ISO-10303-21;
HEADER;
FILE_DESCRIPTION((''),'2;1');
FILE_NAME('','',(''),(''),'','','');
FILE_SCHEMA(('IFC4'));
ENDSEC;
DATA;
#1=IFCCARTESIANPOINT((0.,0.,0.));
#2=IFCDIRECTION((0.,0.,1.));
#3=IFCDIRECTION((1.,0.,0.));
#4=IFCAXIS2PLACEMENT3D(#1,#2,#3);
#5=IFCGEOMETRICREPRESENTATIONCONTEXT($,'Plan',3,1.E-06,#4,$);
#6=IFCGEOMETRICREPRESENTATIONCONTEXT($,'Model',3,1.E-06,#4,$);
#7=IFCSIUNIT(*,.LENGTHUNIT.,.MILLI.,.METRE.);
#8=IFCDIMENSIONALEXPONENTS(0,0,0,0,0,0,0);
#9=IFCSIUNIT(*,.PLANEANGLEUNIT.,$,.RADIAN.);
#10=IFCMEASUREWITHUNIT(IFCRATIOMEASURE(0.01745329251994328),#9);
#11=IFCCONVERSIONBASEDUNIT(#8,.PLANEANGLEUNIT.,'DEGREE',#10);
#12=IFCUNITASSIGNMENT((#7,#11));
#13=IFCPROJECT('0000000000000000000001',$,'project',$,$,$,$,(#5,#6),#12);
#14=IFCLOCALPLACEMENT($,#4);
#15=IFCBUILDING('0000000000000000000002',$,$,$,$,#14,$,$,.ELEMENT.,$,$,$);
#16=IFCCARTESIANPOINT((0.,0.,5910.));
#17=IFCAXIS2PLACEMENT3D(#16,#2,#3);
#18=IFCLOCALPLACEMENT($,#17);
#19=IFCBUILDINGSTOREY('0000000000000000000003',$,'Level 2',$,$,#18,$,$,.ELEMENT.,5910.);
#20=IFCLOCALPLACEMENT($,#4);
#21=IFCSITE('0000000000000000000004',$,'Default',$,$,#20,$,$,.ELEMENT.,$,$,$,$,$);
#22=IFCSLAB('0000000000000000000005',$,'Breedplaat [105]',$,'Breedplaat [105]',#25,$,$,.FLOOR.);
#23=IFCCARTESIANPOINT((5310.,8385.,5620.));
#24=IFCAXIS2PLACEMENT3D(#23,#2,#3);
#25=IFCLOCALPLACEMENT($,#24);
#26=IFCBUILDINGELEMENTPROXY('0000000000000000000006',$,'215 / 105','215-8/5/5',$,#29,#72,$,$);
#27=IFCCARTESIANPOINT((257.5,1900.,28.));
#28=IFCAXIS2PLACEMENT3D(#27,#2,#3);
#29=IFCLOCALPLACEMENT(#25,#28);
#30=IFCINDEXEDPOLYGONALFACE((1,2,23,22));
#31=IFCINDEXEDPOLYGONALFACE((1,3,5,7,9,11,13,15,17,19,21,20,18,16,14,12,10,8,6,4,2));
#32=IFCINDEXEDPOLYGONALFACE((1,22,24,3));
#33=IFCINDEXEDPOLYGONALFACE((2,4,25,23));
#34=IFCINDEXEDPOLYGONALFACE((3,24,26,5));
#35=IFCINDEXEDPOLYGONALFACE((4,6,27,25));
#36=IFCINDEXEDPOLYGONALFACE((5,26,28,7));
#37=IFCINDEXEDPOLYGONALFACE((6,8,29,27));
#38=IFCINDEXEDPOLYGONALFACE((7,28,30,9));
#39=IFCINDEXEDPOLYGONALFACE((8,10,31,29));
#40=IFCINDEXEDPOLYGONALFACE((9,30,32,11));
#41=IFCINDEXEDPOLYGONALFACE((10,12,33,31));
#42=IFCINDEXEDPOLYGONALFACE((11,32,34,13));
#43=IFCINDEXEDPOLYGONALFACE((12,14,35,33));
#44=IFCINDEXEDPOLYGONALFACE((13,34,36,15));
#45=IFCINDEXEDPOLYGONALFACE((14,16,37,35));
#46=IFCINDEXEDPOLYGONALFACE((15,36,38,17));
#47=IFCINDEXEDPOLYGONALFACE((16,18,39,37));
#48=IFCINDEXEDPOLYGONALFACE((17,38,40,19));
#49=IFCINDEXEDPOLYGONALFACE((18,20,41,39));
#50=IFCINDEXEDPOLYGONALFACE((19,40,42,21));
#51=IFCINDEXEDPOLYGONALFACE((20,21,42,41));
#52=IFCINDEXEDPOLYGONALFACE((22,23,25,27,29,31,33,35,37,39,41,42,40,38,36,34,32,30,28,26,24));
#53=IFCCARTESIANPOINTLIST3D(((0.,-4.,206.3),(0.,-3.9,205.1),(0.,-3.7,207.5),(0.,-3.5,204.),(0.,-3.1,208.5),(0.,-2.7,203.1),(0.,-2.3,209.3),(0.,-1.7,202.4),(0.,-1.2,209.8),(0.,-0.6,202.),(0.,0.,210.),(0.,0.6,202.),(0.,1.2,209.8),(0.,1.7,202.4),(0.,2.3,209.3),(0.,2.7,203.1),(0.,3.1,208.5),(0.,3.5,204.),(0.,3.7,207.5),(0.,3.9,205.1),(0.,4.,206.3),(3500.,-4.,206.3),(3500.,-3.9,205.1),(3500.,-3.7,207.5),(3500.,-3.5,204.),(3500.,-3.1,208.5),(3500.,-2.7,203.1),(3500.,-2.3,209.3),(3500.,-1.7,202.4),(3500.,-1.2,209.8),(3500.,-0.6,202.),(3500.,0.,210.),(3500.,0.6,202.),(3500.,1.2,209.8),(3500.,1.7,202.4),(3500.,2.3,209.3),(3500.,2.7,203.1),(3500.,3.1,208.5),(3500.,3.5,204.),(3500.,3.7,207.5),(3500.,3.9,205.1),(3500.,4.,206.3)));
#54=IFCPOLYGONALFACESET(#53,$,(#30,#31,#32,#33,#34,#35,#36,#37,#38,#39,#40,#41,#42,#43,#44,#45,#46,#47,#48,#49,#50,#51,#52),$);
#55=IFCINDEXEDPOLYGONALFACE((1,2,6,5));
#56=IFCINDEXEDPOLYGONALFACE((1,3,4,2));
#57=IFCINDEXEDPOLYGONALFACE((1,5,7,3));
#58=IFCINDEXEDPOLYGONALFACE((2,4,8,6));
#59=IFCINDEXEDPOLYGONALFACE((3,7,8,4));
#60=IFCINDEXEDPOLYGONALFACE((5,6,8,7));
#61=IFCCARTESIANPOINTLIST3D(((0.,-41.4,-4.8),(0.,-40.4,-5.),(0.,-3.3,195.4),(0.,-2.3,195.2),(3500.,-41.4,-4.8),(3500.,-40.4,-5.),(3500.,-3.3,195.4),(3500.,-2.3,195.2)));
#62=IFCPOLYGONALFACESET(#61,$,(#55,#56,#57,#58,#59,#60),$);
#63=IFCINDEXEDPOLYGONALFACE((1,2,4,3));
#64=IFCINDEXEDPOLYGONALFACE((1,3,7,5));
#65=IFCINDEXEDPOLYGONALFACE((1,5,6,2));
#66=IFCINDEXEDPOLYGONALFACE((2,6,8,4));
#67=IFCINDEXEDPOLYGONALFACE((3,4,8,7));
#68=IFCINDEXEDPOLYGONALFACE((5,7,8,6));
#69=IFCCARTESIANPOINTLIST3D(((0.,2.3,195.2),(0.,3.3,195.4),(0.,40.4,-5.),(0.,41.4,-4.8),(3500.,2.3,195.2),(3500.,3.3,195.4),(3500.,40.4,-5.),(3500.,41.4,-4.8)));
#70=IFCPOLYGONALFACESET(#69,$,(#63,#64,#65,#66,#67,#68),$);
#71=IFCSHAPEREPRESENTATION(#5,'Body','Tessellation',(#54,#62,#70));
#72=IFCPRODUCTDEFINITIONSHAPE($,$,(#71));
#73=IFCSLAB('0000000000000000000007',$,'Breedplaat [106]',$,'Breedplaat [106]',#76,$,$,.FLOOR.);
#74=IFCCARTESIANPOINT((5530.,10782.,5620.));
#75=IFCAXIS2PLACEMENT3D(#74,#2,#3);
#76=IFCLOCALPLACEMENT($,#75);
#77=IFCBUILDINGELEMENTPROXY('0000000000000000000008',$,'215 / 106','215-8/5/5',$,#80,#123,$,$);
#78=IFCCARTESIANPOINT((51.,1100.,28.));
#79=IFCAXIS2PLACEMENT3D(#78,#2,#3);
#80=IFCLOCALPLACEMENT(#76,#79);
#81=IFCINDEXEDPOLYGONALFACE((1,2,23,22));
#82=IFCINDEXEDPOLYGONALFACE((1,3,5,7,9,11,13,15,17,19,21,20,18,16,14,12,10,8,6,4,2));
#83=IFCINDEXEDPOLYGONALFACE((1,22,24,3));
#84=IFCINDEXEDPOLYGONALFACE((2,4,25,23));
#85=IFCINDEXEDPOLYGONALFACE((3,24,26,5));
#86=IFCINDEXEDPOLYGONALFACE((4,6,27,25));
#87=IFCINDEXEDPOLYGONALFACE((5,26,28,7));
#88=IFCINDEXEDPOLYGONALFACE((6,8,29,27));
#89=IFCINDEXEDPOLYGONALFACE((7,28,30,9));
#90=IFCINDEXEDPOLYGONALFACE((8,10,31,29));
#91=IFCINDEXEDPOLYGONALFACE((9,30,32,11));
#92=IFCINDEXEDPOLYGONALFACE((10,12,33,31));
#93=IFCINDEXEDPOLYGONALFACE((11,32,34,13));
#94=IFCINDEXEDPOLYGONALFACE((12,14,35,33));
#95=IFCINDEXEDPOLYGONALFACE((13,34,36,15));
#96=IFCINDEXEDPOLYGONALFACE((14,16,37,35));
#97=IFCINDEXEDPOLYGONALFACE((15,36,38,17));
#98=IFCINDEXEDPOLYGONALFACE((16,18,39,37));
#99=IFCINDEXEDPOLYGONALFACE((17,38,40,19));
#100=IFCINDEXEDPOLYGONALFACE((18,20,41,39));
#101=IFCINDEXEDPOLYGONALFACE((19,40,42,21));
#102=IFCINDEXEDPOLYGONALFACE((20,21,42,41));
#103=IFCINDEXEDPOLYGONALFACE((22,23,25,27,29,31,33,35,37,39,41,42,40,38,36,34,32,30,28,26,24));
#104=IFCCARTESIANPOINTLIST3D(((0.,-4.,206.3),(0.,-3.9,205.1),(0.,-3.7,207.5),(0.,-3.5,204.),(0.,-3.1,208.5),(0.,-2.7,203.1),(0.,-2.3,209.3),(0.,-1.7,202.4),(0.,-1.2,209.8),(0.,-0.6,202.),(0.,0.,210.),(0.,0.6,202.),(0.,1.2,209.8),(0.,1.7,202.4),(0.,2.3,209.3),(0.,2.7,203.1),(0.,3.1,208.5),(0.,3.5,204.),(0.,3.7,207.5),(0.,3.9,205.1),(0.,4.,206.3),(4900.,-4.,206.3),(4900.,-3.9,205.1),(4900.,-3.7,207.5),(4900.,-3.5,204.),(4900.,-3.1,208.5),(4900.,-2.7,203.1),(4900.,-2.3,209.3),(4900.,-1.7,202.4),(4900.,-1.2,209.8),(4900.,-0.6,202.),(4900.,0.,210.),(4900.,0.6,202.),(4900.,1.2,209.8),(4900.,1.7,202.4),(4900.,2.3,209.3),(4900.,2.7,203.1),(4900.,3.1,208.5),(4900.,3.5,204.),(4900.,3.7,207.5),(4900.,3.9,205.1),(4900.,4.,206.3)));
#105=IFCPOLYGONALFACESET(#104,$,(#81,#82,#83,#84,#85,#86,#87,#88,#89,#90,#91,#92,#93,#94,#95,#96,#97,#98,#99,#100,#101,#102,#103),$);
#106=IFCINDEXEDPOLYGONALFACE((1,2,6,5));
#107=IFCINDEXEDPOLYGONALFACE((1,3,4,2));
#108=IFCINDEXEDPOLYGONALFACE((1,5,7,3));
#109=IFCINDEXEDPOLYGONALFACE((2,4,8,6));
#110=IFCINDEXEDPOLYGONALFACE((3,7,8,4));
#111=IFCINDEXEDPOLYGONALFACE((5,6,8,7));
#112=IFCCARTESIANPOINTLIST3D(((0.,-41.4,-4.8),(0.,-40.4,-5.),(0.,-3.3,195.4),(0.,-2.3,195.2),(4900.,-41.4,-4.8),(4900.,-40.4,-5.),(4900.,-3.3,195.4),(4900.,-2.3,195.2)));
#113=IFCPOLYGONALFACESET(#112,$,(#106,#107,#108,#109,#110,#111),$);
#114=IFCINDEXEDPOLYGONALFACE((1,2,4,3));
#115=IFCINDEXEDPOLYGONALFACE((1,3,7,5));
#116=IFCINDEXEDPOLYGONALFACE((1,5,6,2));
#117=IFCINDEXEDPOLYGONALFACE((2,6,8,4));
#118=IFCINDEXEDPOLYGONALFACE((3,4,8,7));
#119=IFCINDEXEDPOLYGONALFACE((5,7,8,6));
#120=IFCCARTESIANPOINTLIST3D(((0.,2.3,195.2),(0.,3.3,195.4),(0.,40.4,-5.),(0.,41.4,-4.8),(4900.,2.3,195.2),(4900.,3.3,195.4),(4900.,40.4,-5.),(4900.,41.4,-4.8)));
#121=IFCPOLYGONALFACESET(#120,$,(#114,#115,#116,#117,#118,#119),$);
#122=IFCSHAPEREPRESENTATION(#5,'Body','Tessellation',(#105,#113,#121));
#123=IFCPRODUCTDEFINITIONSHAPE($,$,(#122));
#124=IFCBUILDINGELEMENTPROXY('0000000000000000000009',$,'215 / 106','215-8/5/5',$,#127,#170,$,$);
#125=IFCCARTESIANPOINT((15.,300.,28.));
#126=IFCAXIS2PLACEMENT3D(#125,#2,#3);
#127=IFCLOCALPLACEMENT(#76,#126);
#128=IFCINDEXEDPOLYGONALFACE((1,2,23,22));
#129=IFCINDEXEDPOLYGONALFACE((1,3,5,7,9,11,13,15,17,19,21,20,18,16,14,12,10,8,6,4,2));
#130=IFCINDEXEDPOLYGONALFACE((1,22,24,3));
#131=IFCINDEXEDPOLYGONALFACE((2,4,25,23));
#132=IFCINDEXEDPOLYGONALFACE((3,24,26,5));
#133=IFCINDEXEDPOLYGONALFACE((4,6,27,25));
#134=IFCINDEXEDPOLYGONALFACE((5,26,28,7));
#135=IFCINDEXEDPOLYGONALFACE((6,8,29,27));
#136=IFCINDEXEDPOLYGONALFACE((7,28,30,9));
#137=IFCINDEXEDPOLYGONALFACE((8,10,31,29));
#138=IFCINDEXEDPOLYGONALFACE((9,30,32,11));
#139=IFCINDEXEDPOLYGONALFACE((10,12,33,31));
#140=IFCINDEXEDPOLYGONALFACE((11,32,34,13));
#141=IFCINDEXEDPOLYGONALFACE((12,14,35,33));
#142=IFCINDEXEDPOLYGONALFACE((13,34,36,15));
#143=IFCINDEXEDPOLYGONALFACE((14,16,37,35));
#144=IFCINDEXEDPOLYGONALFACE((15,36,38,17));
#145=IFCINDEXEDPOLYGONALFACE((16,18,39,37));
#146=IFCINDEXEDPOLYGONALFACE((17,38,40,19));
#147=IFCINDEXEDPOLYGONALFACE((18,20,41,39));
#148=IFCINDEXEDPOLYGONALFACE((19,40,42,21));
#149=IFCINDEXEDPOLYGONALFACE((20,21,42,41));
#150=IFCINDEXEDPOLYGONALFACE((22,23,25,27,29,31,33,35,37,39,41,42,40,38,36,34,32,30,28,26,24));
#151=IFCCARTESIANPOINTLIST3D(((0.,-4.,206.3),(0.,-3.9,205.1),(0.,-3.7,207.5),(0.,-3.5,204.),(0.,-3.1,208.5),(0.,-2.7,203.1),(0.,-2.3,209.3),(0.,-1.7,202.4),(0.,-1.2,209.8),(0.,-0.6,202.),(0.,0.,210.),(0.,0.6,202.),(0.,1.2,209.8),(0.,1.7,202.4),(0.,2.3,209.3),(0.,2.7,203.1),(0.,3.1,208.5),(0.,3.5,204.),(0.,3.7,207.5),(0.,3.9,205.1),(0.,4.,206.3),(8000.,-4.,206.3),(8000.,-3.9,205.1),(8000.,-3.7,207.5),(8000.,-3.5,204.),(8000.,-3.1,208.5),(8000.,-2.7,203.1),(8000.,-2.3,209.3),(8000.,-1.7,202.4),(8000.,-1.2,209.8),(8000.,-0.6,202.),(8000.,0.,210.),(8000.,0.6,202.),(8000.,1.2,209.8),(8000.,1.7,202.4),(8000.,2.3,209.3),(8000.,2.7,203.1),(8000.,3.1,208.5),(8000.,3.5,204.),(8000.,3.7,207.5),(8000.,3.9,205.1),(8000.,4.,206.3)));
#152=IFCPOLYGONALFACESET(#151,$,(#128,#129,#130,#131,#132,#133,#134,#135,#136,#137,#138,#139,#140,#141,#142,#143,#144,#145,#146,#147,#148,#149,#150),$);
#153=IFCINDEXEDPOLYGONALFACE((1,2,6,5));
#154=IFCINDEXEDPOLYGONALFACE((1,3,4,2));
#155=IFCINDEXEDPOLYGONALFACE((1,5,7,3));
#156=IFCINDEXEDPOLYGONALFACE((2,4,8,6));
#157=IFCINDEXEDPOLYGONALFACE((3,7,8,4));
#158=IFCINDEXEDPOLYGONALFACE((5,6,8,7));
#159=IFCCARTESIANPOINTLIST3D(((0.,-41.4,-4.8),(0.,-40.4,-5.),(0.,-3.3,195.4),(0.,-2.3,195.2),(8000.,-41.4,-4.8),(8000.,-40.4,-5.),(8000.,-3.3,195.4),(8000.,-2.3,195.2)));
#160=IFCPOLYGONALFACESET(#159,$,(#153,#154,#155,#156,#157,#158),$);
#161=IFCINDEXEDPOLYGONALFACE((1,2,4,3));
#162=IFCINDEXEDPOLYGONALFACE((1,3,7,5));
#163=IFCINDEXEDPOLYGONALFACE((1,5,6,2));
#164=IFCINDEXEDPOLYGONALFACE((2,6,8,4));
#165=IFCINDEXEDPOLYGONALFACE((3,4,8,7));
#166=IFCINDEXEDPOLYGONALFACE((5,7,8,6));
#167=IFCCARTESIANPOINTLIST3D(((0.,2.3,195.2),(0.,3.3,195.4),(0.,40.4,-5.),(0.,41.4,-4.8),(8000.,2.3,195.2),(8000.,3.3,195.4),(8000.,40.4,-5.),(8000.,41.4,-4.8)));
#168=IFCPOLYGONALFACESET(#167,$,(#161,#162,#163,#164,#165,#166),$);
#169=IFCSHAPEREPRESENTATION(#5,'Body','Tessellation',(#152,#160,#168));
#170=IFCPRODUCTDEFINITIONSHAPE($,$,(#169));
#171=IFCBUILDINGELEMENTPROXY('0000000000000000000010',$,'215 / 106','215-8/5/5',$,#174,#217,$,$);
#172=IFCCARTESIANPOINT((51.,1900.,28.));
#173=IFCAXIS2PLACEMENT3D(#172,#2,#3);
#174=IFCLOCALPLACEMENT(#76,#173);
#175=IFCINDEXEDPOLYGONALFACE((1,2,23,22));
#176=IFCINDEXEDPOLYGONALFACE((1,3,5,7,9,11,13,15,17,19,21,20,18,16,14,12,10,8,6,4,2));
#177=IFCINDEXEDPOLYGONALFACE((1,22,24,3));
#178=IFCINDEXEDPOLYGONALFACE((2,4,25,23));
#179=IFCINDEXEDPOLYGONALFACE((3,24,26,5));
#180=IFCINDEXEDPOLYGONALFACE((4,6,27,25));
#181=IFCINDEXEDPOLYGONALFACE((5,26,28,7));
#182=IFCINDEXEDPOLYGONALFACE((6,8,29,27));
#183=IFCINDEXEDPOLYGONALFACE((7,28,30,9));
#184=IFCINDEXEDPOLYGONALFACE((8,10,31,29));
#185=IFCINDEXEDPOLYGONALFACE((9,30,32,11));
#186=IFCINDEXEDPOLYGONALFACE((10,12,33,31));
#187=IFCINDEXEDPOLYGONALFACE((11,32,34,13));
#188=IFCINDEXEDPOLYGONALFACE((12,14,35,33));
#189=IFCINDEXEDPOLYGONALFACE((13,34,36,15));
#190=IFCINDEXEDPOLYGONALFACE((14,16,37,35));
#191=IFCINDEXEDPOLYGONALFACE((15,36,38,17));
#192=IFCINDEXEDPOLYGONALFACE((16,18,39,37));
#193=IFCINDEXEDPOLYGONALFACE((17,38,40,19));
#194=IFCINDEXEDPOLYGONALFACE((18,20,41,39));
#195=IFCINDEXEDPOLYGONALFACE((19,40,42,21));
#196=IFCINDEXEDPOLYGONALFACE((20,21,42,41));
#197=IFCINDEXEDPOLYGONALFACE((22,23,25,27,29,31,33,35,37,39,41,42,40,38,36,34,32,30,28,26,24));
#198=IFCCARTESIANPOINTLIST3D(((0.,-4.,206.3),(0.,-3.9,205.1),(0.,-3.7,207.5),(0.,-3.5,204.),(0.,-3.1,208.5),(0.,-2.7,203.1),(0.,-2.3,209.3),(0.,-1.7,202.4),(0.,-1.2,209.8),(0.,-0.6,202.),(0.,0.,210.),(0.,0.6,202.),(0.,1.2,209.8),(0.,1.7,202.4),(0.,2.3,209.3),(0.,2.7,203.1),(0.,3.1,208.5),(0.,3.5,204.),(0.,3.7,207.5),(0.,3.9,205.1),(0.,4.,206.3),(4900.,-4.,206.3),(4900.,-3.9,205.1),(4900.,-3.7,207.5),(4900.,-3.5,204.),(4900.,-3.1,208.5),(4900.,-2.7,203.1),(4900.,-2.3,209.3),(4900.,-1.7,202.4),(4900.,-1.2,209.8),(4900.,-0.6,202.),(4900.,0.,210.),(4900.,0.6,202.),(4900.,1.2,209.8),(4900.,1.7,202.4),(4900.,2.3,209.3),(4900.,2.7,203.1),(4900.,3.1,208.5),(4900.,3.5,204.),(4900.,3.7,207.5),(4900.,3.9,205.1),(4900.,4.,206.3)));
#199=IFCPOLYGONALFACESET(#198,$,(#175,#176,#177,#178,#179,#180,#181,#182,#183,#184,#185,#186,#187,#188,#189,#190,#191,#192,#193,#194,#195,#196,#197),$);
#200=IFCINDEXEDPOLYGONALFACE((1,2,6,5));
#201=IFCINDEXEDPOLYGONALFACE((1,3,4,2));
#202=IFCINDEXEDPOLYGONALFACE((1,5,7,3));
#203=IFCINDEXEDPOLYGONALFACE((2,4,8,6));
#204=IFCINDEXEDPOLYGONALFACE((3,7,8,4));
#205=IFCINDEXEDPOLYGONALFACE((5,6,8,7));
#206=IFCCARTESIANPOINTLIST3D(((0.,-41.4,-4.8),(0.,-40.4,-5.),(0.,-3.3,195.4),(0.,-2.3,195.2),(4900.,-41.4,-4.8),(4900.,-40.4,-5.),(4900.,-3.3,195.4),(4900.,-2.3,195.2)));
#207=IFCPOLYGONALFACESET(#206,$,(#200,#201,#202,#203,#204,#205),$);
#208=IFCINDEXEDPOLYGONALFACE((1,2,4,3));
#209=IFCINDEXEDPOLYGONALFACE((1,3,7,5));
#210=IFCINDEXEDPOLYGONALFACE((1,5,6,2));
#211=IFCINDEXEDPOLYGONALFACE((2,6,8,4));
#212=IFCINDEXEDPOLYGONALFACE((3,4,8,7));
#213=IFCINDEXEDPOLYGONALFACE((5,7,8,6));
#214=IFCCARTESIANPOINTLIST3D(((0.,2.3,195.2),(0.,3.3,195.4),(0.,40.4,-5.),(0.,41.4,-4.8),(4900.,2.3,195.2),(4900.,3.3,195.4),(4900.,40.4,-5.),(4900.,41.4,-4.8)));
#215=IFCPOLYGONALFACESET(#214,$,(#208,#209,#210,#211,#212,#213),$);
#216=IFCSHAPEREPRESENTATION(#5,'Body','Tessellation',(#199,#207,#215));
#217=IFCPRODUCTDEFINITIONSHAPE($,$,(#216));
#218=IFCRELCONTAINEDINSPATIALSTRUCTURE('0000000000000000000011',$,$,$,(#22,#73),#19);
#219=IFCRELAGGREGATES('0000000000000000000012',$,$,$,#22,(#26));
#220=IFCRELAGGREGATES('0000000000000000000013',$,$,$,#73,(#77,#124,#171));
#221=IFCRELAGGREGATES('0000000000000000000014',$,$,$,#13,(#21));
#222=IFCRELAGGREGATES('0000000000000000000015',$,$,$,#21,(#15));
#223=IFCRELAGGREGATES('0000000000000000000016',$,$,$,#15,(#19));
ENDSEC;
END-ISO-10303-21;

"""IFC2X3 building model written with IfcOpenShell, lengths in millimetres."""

from ifc_helpers import new_model, entity, si_unit, converted_unit, frame, origin_with_axes, origin_2d_with_axis, place, context, project, spatial, rectangle, circle, extrude, element, aggregate, save


model = new_model("IFC2X3")

# Units and contexts
plan_context = context("Plan", 3, precision=1e-06, world=origin_with_axes())
model_context = context("Model", 3, precision=1e-06, world=origin_with_axes())
ifc_project = project(units=[si_unit("LENGTHUNIT", "METRE", prefix="MILLI"), converted_unit("PLANEANGLEUNIT", "DEGREE", entity("IfcRatioMeasure", 0.01745329251994328), si_unit("PLANEANGLEUNIT", "RADIAN"), dimensions=[0, 0, 0, 0, 0, 0, 0])], contexts=[plan_context, model_context])

# Site, building, storey
site_placement = place(None, origin_with_axes())
site = spatial("IfcSite", under=ifc_project, at=site_placement, Name="Default", CompositionType="ELEMENT")
building_placement = place(None, origin_with_axes())
building = spatial("IfcBuilding", under=site, at=building_placement, CompositionType="ELEMENT")
storey_placement = place(None, frame((0.0, 0.0, 5910.0), z_axis=(0.0, 0.0, 1.0), x_axis=(1.0, 0.0, 0.0)))
storey = spatial("IfcBuildingStorey", under=building, at=storey_placement, Name="Level 2", CompositionType="ELEMENT", Elevation=5910.0)

# Slab, building element proxy
slab_1_placement = place(None, frame((5310.0, 8385.0, 5620.0), z_axis=(0.0, 0.0, 1.0), x_axis=(1.0, 0.0, 0.0)))
slab_1 = element("IfcSlab", 1, at=slab_1_placement, inside=storey, Name="Breedplaat [105]", ObjectType="Breedplaat [105]", PredefinedType="FLOOR")
proxy_1_placement = place(slab_1_placement, frame((257.5, 1900.0, 28.0), z_axis=(0.0, 0.0, 1.0), x_axis=(1.0, 0.0, 0.0)))
proxy_1 = element("IfcBuildingElementProxy", 2, at=proxy_1_placement, Name="215 / 105", Description="215-8/5/5", context=plan_context, shape_type="SweptSolid", body=[
    extrude(circle(Radius=4.0, at=origin_2d_with_axis()), frame((0.0, 0.0, 206.0), z_axis=(1.0, 0.0, 0.0), x_axis=(0.0, 0.0, 1.0)), (0.0, 0.0, 1.0), 3500.0),
    extrude(rectangle(XDim=203.8, YDim=1.0, at=origin_2d_with_axis()), frame((0.0, -21.9, 95.2), z_axis=(1.0, 0.0, 0.0), x_axis=(0.0, 0.187112, 0.982339)), (0.0, 0.0, 1.0), 3500.0),
    extrude(rectangle(XDim=203.8, YDim=1.0, at=origin_2d_with_axis()), frame((0.0, 21.9, 95.2), z_axis=(1.0, 0.0, 0.0), x_axis=(0.0, -0.187112, 0.982339)), (0.0, 0.0, 1.0), 3500.0),
])
aggregate(slab_1, [proxy_1])

# Slab, building element proxies
slab_2_placement = place(None, frame((5530.0, 10782.0, 5620.0), z_axis=(0.0, 0.0, 1.0), x_axis=(1.0, 0.0, 0.0)))
slab_2 = element("IfcSlab", 3, at=slab_2_placement, inside=storey, Name="Breedplaat [106]", ObjectType="Breedplaat [106]", PredefinedType="FLOOR")
proxy_2_placement = place(slab_2_placement, frame((51.0, 1100.0, 28.0), z_axis=(0.0, 0.0, 1.0), x_axis=(1.0, 0.0, 0.0)))
proxy_2 = element("IfcBuildingElementProxy", 4, at=proxy_2_placement, Name="215 / 106", Description="215-8/5/5", context=plan_context, shape_type="SweptSolid", body=[
    extrude(circle(Radius=4.0, at=origin_2d_with_axis()), frame((0.0, 0.0, 206.0), z_axis=(1.0, 0.0, 0.0), x_axis=(0.0, 0.0, 1.0)), (0.0, 0.0, 1.0), 4900.0),
    extrude(rectangle(XDim=203.8, YDim=1.0, at=origin_2d_with_axis()), frame((0.0, -21.9, 95.2), z_axis=(1.0, 0.0, 0.0), x_axis=(0.0, 0.187112, 0.982339)), (0.0, 0.0, 1.0), 4900.0),
    extrude(rectangle(XDim=203.8, YDim=1.0, at=origin_2d_with_axis()), frame((0.0, 21.9, 95.2), z_axis=(1.0, 0.0, 0.0), x_axis=(0.0, -0.187112, 0.982339)), (0.0, 0.0, 1.0), 4900.0),
])
proxy_3_placement = place(slab_2_placement, frame((15.0, 300.0, 28.0), z_axis=(0.0, 0.0, 1.0), x_axis=(1.0, 0.0, 0.0)))
proxy_3 = element("IfcBuildingElementProxy", 5, at=proxy_3_placement, Name="215 / 106", Description="215-8/5/5", context=plan_context, shape_type="SweptSolid", body=[
    extrude(circle(Radius=4.0, at=origin_2d_with_axis()), frame((0.0, 0.0, 206.0), z_axis=(1.0, 0.0, 0.0), x_axis=(0.0, 0.0, 1.0)), (0.0, 0.0, 1.0), 8000.0),
    extrude(rectangle(XDim=203.8, YDim=1.0, at=origin_2d_with_axis()), frame((0.0, -21.9, 95.2), z_axis=(1.0, 0.0, 0.0), x_axis=(0.0, 0.187112, 0.982339)), (0.0, 0.0, 1.0), 8000.0),
    extrude(rectangle(XDim=203.8, YDim=1.0, at=origin_2d_with_axis()), frame((0.0, 21.9, 95.2), z_axis=(1.0, 0.0, 0.0), x_axis=(0.0, -0.187112, 0.982339)), (0.0, 0.0, 1.0), 8000.0),
])
proxy_4_placement = place(slab_2_placement, frame((51.0, 1900.0, 28.0), z_axis=(0.0, 0.0, 1.0), x_axis=(1.0, 0.0, 0.0)))
proxy_4 = element("IfcBuildingElementProxy", 6, at=proxy_4_placement, Name="215 / 106", Description="215-8/5/5", context=plan_context, shape_type="SweptSolid", body=[
    extrude(circle(Radius=4.0, at=origin_2d_with_axis()), frame((0.0, 0.0, 206.0), z_axis=(1.0, 0.0, 0.0), x_axis=(0.0, 0.0, 1.0)), (0.0, 0.0, 1.0), 4900.0),
    extrude(rectangle(XDim=203.8, YDim=1.0, at=origin_2d_with_axis()), frame((0.0, -21.9, 95.2), z_axis=(1.0, 0.0, 0.0), x_axis=(0.0, 0.187112, 0.982339)), (0.0, 0.0, 1.0), 4900.0),
    extrude(rectangle(XDim=203.8, YDim=1.0, at=origin_2d_with_axis()), frame((0.0, 21.9, 95.2), z_axis=(1.0, 0.0, 0.0), x_axis=(0.0, -0.187112, 0.982339)), (0.0, 0.0, 1.0), 4900.0),
])
aggregate(slab_2, [proxy_2, proxy_3, proxy_4])

save(model, "model.ifc")
